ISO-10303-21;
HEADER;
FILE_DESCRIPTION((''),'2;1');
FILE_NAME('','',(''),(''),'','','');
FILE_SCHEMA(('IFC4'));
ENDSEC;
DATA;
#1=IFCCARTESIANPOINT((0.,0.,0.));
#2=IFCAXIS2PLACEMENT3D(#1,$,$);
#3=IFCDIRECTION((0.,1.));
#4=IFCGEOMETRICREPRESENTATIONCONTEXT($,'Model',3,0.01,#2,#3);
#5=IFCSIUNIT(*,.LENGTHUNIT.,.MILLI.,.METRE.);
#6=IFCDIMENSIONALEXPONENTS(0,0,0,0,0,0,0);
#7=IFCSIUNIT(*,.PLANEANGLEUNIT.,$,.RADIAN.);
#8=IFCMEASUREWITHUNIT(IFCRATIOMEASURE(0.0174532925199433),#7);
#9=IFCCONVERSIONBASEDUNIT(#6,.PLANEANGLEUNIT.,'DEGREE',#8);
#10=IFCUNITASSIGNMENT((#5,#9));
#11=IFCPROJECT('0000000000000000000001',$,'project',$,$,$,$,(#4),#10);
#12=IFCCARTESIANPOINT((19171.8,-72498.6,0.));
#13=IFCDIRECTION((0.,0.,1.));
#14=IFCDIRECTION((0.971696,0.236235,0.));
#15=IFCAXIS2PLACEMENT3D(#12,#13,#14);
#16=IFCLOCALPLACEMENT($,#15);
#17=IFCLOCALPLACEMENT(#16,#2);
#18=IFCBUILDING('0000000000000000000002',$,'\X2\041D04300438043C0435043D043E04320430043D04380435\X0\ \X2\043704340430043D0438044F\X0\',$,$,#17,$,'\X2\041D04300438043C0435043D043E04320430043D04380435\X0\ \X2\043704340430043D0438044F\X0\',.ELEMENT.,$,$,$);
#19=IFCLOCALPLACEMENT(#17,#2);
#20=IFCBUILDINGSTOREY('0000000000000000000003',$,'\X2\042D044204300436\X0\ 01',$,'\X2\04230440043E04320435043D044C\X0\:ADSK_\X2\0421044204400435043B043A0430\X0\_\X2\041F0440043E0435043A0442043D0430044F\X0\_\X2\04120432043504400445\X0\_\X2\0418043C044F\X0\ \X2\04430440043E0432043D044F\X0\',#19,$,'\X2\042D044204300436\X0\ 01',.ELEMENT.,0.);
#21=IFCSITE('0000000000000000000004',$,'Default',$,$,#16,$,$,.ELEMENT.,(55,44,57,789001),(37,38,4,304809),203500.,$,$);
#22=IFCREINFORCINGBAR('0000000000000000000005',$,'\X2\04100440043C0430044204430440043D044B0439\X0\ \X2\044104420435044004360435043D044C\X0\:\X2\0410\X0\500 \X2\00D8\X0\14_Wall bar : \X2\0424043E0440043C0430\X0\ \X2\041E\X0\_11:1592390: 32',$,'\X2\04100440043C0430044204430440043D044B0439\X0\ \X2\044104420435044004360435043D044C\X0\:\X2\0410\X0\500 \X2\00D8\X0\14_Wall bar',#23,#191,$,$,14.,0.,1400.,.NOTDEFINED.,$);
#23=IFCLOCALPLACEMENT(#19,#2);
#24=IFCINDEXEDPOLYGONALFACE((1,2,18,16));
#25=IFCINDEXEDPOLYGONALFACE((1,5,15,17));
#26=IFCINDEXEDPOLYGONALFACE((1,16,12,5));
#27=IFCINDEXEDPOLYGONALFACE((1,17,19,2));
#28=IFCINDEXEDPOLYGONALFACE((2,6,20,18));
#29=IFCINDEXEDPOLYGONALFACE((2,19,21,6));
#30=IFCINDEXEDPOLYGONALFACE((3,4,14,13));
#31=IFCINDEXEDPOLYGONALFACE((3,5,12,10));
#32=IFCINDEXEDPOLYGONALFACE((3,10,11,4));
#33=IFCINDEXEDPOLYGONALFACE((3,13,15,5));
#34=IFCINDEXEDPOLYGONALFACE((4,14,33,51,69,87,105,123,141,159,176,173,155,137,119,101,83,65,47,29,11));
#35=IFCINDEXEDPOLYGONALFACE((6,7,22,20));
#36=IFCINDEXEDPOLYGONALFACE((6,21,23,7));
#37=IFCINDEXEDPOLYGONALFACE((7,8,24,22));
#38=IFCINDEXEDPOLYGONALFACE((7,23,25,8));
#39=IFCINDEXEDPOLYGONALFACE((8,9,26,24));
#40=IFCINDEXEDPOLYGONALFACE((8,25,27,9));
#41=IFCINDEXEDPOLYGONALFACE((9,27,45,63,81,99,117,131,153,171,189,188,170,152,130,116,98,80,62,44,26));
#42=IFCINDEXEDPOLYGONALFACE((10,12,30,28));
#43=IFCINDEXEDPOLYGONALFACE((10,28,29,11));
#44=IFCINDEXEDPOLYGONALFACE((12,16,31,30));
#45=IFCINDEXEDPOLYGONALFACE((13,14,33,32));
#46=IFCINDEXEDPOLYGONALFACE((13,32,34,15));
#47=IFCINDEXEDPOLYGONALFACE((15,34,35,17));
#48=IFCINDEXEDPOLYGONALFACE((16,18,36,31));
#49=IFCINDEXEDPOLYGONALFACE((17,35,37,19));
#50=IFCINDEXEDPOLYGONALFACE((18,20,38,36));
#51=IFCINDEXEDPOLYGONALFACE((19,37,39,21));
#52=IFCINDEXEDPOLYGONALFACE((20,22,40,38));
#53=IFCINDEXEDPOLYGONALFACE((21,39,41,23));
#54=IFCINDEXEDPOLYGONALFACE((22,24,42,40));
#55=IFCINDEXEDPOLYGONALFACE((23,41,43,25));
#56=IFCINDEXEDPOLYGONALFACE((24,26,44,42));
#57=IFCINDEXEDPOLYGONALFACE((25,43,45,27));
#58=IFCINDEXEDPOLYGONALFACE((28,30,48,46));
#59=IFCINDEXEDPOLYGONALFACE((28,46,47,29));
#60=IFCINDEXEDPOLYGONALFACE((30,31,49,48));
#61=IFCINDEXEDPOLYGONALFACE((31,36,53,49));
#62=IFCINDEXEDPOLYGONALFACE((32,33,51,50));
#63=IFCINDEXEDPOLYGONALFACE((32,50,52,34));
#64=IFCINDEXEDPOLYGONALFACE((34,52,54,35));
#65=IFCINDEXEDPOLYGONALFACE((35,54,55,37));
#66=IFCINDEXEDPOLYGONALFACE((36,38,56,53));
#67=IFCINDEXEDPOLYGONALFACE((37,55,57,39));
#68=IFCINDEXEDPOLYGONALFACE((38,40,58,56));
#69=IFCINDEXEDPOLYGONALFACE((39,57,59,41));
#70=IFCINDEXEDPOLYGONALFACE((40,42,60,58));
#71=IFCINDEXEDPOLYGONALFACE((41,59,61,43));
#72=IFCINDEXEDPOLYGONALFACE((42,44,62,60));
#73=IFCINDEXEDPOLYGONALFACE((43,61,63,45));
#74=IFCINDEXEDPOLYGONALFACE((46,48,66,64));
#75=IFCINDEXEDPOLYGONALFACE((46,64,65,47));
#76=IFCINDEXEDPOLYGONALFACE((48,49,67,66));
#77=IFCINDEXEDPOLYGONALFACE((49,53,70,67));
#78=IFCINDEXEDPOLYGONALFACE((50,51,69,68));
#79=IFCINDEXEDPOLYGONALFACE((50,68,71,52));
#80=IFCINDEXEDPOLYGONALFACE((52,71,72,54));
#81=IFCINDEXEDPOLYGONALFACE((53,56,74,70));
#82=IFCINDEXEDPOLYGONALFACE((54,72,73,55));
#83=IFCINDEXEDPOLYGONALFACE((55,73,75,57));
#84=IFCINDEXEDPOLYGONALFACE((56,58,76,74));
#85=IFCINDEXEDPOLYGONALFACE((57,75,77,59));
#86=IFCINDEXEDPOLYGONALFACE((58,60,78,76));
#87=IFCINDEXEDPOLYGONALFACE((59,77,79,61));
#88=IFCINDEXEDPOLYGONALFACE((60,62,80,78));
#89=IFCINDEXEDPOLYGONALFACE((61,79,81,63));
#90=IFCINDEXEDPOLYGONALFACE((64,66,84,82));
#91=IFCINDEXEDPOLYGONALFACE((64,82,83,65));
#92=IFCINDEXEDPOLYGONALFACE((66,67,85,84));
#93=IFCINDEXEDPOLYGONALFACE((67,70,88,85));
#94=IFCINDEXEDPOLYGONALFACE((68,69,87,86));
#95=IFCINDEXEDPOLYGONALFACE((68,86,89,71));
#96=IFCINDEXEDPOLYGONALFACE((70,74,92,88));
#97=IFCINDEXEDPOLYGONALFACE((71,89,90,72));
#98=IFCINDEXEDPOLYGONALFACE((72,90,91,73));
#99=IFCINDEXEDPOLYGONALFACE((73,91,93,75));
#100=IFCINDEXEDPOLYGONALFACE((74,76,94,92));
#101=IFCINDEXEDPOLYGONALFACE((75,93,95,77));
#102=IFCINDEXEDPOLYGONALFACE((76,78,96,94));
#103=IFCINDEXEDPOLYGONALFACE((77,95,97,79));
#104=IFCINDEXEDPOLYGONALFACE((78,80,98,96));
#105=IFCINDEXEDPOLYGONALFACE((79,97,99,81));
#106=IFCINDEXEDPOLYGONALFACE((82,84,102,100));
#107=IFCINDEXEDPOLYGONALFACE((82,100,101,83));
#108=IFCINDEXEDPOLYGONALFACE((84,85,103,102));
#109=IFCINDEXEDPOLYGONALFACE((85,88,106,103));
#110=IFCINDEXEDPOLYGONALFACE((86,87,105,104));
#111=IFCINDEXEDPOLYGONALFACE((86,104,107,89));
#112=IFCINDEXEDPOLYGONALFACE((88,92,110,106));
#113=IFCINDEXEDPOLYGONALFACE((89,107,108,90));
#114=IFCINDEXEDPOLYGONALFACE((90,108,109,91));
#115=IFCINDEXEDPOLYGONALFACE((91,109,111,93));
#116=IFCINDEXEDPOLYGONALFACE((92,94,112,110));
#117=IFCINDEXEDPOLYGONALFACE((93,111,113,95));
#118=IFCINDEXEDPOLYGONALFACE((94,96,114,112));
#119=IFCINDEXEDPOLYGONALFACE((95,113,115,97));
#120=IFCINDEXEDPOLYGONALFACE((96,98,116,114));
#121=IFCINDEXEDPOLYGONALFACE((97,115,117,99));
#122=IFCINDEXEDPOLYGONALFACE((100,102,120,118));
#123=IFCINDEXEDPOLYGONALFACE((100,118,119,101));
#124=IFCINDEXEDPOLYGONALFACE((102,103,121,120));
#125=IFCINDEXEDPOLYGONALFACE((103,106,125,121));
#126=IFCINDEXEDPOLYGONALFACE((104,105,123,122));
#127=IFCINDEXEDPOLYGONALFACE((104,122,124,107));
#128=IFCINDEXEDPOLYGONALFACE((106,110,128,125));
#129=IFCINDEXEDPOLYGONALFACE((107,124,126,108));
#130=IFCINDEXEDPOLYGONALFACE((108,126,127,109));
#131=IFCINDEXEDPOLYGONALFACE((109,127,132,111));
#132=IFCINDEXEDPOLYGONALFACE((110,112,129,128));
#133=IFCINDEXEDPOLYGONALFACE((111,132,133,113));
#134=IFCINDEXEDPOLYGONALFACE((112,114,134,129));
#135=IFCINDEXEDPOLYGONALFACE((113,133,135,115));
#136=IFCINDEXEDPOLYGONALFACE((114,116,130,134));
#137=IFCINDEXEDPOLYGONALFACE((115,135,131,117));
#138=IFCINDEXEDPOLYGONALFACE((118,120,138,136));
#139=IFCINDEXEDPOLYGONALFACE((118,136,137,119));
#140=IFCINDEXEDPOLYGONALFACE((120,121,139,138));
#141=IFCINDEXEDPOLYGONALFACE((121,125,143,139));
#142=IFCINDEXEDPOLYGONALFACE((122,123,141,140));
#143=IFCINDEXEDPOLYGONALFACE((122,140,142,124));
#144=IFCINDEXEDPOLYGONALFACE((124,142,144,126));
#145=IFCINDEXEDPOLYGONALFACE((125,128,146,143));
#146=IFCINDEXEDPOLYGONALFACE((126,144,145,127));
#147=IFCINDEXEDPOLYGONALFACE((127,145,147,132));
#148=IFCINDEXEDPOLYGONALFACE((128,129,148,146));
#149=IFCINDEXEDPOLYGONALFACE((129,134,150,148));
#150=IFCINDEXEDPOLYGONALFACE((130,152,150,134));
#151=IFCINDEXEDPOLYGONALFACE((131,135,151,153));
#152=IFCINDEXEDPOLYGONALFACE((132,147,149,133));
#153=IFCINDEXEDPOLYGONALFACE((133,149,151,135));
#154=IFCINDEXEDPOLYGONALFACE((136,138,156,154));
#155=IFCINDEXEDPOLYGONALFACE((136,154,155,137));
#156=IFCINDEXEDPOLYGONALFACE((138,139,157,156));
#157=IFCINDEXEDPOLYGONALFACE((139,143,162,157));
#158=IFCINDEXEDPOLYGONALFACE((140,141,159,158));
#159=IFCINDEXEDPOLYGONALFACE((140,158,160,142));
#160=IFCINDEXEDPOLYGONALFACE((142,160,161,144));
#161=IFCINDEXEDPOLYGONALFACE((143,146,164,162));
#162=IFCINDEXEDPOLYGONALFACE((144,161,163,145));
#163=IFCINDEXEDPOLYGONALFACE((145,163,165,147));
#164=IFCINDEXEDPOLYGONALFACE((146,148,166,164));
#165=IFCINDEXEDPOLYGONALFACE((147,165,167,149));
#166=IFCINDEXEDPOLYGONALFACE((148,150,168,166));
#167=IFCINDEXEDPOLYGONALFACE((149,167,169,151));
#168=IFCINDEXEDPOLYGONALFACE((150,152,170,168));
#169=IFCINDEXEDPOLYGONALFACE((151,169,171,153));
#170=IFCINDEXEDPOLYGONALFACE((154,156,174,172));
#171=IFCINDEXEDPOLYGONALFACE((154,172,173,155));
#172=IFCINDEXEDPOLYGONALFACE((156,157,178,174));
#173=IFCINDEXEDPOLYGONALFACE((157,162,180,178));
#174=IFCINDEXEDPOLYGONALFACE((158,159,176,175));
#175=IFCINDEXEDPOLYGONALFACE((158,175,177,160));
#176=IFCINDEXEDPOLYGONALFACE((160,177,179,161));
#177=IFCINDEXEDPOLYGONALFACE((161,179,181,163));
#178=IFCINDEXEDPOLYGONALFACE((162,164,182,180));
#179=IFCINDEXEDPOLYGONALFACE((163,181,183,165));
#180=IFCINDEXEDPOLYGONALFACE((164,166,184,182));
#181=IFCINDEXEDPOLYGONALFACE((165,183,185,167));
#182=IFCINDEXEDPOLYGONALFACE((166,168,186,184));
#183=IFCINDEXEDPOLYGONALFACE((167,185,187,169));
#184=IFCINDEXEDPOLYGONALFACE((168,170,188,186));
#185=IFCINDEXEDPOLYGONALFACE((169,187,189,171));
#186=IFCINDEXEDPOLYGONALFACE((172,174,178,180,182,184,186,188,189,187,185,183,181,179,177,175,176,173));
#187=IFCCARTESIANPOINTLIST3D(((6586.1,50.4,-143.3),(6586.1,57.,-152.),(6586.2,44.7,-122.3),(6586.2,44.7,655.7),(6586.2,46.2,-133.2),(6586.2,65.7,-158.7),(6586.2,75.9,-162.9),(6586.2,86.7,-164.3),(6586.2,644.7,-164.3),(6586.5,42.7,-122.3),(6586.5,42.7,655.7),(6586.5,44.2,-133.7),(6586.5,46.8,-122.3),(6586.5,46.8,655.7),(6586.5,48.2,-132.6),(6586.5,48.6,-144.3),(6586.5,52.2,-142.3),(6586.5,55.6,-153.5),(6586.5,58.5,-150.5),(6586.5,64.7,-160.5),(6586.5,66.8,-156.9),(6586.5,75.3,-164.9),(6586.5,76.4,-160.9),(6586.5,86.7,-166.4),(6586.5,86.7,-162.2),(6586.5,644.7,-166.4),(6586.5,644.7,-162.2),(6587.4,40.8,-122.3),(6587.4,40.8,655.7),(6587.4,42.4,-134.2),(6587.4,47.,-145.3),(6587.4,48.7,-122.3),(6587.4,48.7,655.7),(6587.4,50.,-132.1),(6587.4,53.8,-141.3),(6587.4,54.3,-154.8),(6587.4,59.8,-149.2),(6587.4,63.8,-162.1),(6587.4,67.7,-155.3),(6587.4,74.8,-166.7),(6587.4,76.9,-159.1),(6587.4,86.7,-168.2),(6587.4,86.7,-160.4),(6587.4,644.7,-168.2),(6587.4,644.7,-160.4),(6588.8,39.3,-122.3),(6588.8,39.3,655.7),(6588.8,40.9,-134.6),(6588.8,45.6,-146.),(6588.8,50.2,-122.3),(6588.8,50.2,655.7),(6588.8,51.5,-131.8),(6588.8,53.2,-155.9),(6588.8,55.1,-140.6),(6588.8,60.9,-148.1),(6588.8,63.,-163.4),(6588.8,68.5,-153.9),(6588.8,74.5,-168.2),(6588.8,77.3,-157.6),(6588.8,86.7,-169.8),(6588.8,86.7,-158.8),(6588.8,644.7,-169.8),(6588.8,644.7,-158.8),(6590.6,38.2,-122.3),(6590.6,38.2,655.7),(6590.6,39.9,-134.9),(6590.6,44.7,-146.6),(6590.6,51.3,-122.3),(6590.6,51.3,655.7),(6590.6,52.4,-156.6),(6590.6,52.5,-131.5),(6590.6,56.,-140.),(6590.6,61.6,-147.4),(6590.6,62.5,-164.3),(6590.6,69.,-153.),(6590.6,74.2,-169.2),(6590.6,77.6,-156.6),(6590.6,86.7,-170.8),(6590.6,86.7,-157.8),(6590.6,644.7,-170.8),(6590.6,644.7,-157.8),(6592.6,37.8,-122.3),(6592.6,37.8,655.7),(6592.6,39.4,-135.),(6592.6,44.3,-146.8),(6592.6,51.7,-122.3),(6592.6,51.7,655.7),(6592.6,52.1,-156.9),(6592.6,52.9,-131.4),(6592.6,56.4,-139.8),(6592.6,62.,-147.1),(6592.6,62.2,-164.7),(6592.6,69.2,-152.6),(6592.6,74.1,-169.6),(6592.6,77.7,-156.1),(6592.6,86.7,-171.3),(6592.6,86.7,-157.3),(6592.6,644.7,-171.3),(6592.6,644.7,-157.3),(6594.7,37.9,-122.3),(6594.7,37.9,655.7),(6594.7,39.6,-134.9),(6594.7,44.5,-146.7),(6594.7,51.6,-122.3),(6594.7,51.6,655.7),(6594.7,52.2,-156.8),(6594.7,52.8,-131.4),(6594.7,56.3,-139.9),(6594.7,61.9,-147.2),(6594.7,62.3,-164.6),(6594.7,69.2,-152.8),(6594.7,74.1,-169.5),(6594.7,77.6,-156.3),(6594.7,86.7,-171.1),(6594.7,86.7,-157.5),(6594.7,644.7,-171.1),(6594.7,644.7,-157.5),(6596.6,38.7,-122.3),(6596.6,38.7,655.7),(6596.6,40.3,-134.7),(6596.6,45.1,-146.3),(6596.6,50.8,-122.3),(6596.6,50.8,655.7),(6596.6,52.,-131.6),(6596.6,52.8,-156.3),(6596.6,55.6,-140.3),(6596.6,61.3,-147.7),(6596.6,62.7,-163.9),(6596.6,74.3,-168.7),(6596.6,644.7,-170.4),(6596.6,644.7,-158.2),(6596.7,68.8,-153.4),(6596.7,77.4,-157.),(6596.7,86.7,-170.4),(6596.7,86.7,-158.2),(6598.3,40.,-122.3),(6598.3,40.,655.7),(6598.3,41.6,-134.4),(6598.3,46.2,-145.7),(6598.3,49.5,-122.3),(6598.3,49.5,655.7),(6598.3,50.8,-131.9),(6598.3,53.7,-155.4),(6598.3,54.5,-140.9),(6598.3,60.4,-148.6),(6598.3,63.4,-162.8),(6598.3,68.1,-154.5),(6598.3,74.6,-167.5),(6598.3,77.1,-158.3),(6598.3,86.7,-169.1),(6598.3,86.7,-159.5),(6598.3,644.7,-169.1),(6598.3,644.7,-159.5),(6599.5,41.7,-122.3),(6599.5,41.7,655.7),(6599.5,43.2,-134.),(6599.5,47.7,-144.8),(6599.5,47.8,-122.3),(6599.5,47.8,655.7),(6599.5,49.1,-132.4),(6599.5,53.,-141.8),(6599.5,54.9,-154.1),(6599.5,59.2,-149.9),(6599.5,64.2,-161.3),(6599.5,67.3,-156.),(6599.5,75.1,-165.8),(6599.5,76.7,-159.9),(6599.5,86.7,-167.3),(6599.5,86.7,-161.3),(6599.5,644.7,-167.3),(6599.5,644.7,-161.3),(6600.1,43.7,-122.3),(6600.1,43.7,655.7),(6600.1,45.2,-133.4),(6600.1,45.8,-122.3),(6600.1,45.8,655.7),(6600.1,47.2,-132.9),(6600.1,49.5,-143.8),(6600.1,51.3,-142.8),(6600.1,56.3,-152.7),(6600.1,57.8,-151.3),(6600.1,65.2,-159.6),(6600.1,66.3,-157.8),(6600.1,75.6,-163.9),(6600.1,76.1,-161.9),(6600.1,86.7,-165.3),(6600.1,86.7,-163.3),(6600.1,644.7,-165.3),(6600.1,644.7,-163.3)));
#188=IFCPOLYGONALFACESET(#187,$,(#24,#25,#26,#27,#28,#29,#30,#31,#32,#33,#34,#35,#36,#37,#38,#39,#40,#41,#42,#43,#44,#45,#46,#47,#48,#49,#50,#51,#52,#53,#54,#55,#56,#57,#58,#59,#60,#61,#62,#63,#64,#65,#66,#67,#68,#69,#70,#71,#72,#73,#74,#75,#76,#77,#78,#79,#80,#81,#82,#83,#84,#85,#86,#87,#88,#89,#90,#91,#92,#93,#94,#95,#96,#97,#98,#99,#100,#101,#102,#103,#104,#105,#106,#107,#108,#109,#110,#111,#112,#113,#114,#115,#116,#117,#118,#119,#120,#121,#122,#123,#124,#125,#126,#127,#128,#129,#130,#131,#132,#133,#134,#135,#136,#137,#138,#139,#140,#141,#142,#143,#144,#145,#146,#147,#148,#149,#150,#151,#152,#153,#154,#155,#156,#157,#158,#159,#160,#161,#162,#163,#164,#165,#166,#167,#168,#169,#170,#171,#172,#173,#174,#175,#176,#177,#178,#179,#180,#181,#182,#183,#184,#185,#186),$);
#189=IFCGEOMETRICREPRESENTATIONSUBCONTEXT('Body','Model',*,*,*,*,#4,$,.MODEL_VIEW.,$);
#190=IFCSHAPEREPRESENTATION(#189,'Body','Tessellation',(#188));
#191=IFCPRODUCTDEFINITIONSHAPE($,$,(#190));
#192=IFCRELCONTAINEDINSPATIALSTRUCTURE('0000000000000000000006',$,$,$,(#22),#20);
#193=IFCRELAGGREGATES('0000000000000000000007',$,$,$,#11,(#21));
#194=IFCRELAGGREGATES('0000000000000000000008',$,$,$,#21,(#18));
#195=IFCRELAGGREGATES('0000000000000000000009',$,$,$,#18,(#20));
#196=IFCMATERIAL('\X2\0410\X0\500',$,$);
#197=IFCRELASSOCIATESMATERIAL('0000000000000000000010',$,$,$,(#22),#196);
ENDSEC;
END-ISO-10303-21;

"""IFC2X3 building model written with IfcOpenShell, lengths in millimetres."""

from ifc_helpers import new_model, entity, si_unit, converted_unit, direction, frame, origin, place, context, subcontext, project, spatial, material, element, save


model = new_model("IFC2X3")

# Units and contexts
model_context = context("Model", 3, precision=0.01, world=origin(), true_north=direction((0.0, 1.0)))
body_context = subcontext(model_context, "Body", "Model", "MODEL_VIEW")
ifc_project = project(units=[si_unit("LENGTHUNIT", "METRE", prefix="MILLI"), converted_unit("PLANEANGLEUNIT", "DEGREE", entity("IfcRatioMeasure", 0.0174532925199433), si_unit("PLANEANGLEUNIT", "RADIAN"), dimensions=[0, 0, 0, 0, 0, 0, 0])], contexts=[model_context])

# Site, building, storey
site_placement = place(None, frame((19171.8, -72498.6, 0.0), z_axis=(0.0, 0.0, 1.0), x_axis=(0.971696, 0.236235, 0.0)))
site = spatial("IfcSite", under=ifc_project, at=site_placement, Name="Default", CompositionType="ELEMENT", RefLatitude=(55, 44, 57, 789001), RefLongitude=(37, 38, 4, 304809), RefElevation=203500.0)
building_placement = place(site_placement, origin())
building = spatial("IfcBuilding", under=site, at=building_placement, Name="Наименование здания", LongName="Наименование здания", CompositionType="ELEMENT")
storey_placement = place(building_placement, origin())
storey = spatial("IfcBuildingStorey", under=building, at=storey_placement, Name="Этаж 01", ObjectType="Уровень:ADSK_Стрелка_Проектная_Вверх_Имя уровня", LongName="Этаж 01", CompositionType="ELEMENT", Elevation=0.0)

# Reinforcing bar
ifc_material = material(Name="А500")
placement = place(storey_placement, origin())
element("IfcReinforcingBar", 1, at=placement, inside=storey, material=ifc_material, Name="Арматурный стержень:А500 Ø14_Wall bar : Форма О_11:1592390: 32", ObjectType="Арматурный стержень:А500 Ø14_Wall bar", BarLength=1400.0, BarRole="NOTDEFINED", CrossSectionArea=0.0, NominalDiameter=14.0, context=body_context, shape_type="AdvancedSweptSolid", body=[
    entity("IfcSweptDiskSolid", entity("IfcCompositeCurve", [entity("IfcCompositeCurveSegment", "CONTINUOUS", True, entity("IfcPolyline", [entity("IfcCartesianPoint", [6593.1, 44.7, 655.7]), entity("IfcCartesianPoint", [6593.1, 44.7, -122.3])])), entity("IfcCompositeCurveSegment", "CONTINUOUS", True, entity("IfcTrimmedCurve", entity("IfcCircle", entity("IfcAxis2Placement3D", entity("IfcCartesianPoint", [6593.1, 86.7, -122.3]), entity("IfcDirection", [1.0, 0.0, 0.0]), entity("IfcDirection", [0.0, 0.0, -1.0])), 42.0), [entity("IfcParameterValue", 270.0)], [entity("IfcParameterValue", 360.0)], True, "PARAMETER")), entity("IfcCompositeCurveSegment", "CONTINUOUS", True, entity("IfcPolyline", [entity("IfcCartesianPoint", [6593.1, 86.7, -164.3]), entity("IfcCartesianPoint", [6593.1, 644.7, -164.3])]))], False), 7.0, None, 0.0, 92.0),
])

save(model, "model.ifc")
